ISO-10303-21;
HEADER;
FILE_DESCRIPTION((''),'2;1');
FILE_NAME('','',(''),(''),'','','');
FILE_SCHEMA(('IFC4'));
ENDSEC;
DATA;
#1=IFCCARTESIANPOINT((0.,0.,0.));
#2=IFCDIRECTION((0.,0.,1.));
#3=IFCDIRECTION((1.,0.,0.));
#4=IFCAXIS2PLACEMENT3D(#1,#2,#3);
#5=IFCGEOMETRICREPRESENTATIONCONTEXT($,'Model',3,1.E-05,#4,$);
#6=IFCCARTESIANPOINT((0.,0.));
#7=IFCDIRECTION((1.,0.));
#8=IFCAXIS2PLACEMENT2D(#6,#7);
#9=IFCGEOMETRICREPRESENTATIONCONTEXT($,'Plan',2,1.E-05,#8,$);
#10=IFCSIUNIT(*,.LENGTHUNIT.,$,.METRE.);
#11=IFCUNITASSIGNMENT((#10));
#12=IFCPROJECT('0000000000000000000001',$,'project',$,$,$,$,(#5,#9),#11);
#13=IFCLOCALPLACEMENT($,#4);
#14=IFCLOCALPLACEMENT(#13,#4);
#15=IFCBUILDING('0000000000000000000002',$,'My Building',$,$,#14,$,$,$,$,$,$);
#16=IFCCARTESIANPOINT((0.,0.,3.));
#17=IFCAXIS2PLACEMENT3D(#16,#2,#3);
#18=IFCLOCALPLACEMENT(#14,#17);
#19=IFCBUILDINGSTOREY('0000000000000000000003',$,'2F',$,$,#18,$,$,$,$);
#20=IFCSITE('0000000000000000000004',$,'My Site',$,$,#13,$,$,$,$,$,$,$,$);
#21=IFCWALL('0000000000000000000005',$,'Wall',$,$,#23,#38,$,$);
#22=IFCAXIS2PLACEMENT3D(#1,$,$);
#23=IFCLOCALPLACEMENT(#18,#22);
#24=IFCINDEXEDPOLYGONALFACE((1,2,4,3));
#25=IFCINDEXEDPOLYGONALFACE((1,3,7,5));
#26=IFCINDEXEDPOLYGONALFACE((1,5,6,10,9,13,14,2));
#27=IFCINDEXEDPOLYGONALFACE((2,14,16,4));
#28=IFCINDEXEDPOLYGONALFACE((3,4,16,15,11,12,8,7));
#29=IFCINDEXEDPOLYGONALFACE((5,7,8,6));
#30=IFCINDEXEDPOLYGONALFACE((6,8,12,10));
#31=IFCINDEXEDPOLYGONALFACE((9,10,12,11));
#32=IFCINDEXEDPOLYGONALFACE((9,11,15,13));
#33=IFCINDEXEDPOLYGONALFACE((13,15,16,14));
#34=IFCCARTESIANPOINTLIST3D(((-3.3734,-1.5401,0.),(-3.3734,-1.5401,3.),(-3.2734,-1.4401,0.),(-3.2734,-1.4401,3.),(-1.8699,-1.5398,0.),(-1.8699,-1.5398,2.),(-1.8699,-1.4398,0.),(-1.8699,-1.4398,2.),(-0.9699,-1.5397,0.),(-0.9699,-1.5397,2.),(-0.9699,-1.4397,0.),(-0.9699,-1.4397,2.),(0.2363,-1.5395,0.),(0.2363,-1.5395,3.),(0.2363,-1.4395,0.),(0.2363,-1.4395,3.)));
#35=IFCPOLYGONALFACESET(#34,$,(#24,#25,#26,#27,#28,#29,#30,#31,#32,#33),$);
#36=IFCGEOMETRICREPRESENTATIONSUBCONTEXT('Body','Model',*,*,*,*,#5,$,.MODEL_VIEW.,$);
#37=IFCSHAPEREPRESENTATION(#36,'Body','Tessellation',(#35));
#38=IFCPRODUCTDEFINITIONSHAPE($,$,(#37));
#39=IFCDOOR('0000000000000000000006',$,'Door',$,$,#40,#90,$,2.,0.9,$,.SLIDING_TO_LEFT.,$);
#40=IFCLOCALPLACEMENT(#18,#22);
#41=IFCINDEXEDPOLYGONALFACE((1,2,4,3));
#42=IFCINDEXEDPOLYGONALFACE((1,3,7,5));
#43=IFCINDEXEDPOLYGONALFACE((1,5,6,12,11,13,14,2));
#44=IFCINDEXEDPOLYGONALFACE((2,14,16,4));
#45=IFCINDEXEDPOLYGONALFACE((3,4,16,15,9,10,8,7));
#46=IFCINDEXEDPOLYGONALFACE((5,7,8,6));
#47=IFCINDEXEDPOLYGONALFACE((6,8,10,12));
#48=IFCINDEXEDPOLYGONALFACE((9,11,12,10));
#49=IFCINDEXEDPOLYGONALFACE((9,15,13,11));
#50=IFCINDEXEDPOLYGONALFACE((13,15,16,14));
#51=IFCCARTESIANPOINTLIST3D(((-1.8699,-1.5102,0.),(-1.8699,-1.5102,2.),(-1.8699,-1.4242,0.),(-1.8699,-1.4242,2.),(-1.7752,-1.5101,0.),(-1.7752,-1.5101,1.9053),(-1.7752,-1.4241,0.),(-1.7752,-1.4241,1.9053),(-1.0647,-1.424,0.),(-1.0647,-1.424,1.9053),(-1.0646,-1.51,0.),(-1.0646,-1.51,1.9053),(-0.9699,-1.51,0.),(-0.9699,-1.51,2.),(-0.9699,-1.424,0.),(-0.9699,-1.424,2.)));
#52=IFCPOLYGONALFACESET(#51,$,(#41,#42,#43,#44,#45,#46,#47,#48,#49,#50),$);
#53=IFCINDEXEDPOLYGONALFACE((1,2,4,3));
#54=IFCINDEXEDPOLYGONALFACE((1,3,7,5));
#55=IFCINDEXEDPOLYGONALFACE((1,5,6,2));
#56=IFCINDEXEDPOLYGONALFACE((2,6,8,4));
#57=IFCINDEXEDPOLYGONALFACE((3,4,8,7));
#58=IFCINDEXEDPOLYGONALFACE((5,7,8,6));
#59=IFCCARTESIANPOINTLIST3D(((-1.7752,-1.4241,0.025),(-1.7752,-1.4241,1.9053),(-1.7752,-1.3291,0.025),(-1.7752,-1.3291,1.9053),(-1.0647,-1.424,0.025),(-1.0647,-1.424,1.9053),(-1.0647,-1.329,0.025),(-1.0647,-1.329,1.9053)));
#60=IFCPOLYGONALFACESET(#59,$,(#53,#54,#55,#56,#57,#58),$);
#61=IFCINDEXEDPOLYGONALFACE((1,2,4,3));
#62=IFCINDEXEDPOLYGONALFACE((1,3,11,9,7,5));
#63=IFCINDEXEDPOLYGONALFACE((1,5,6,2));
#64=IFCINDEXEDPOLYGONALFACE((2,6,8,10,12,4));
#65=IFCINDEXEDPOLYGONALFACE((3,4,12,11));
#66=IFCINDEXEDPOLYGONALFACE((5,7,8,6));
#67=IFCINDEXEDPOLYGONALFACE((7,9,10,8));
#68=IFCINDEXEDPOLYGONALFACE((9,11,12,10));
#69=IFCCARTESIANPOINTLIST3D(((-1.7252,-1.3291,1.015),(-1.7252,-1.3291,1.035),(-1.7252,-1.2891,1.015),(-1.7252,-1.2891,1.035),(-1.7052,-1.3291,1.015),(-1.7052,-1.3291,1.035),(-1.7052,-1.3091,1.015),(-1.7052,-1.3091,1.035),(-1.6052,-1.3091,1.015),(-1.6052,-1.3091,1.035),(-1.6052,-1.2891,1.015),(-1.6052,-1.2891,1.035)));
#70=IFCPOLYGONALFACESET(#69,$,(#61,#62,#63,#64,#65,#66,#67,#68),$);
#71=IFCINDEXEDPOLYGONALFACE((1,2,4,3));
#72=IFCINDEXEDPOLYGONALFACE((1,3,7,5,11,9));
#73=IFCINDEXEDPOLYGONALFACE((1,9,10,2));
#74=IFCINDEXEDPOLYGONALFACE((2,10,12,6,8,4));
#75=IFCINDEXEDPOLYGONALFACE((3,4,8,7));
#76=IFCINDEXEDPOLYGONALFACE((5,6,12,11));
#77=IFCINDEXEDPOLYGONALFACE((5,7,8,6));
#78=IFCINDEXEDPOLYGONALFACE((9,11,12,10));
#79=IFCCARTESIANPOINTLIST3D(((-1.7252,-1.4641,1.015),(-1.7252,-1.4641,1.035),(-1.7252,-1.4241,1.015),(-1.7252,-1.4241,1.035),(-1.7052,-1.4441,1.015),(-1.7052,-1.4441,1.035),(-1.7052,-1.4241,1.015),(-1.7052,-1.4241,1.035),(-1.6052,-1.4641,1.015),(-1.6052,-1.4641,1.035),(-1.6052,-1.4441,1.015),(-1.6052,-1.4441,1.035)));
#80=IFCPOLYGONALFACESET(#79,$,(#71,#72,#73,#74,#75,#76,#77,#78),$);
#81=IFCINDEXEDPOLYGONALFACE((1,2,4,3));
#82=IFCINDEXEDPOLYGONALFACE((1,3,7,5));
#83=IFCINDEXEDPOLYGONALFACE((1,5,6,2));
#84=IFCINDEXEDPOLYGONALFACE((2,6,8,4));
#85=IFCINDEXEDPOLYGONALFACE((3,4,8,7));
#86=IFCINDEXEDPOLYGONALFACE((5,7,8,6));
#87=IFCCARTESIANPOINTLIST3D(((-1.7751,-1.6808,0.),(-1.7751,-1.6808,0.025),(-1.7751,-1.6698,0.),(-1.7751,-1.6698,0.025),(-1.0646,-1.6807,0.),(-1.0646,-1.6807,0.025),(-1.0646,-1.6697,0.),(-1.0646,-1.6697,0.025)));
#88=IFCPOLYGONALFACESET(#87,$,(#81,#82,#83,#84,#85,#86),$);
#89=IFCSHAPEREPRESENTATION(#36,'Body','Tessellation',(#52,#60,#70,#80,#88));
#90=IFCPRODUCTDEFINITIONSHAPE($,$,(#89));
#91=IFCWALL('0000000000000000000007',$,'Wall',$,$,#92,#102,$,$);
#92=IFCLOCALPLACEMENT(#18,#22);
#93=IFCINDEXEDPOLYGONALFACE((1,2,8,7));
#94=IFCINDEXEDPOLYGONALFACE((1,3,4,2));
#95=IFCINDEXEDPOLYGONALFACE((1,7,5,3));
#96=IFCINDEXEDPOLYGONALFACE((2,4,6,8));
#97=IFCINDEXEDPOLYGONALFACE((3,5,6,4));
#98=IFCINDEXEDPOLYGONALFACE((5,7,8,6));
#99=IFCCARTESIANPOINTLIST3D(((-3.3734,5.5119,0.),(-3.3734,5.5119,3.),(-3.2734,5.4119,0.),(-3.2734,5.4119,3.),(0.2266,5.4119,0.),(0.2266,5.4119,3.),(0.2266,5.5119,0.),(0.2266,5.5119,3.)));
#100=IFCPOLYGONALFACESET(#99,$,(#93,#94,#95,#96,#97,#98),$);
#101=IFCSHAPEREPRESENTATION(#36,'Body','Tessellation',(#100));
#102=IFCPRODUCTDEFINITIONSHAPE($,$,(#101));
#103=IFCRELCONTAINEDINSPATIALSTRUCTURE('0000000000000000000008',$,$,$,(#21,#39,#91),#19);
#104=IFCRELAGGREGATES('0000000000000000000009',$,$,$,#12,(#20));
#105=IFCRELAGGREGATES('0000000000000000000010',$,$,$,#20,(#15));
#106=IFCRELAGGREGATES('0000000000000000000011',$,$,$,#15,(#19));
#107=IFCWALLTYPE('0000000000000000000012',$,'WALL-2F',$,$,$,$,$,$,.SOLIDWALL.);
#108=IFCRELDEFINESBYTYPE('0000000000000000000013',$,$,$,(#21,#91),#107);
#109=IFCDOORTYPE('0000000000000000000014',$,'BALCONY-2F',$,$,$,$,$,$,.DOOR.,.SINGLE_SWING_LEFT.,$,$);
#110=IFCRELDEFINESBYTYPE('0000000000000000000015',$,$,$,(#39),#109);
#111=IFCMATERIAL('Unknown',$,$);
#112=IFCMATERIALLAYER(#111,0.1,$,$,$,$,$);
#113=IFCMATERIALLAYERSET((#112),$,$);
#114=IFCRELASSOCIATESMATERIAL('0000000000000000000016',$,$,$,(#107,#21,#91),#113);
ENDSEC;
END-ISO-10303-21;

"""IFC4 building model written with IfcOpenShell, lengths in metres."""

from ifc_helpers import new_model, entity, si_unit, frame, origin_with_axes, origin_2d_with_axis, place, context, subcontext, project, spatial, line, indexed_curve, outline, extrude, shape, source, transform, mapped, material, layer, layer_set, layer_usage, type_object, type_shapes, element, fill, save


model = new_model("IFC4")

# Units and contexts
model_context = context("Model", 3, precision=1e-05, world=origin_with_axes())
plan_context = context("Plan", 2, precision=1e-05, world=origin_2d_with_axis())
body_context_1 = subcontext(model_context, "Body", "Model", "MODEL_VIEW")
body_context_2 = subcontext(plan_context, "Body", "Plan", "PLAN_VIEW")
ifc_project = project(units=[si_unit("LENGTHUNIT", "METRE")], contexts=[model_context, plan_context])

# Site, building, storey
site_placement = place(None, origin_with_axes())
site = spatial("IfcSite", under=ifc_project, at=site_placement, Name="My Site")
building_placement = place(site_placement, origin_with_axes())
building = spatial("IfcBuilding", under=site, at=building_placement, Name="My Building")
storey_placement = place(building_placement, frame((0.0, 0.0, 3.0), z_axis=(0.0, 0.0, 1.0), x_axis=(1.0, 0.0, 0.0)))
storey = spatial("IfcBuildingStorey", under=building, at=storey_placement, Name="2F")

# Shared definitions
ifc_material = material(Name="Unknown")

# Shared definitions
ifc_layer_1 = layer(ifc_material, 0.1)
ifc_layer_set_1 = layer_set([ifc_layer_1])
wall_type = type_object("IfcWallType", Name="WALL-2F", PredefinedType="SOLIDWALL", material=ifc_layer_set_1)

# Wall, opening, door
ifc_layer_usage_1 = layer_usage(ifc_layer_set_1, "AXIS2", "POSITIVE", 0.0)
wall_1_placement = place(storey_placement, frame((-3.3734, -1.5401, 0.0), z_axis=(0.0, 0.0, 1.0), x_axis=(1.0, 0.000183, 0.0)))
wall_1 = element("IfcWall", 1, at=wall_1_placement, inside=storey, type_object=wall_type, material=ifc_layer_usage_1, Name="Wall", context=body_context_1, shape_type="SweptSolid", body=[
    extrude(outline(indexed_curve([(0.0, 0.0), (0.1, 0.1), (3.6097, 0.1), (3.6097, 0.0)], segments=[line(1, 2, 3, 4, 1)])), origin_with_axes(), (0.0, 0.0, 1.0), 3.0),
])
shared_shape_1 = source(origin_with_axes(), body_context_1, "Body", "SweptSolid", [
    extrude(outline(indexed_curve([(0.0, 0.0), (0.9, 0.0), (0.9, 2.0), (0.0, 2.0)], segments=[line(1, 2, 3, 4, 1)])), frame((0.0, -0.6, 0.0), z_axis=(0.0, -1.0, 0.0), x_axis=(1.0, 0.0, 0.0)), (0.0, 0.0, -1.0), 1.2),
])
opening_1_placement = place(wall_1_placement, frame((2.4035, 0.1, 0.0), z_axis=(0.0, 0.0, 1.0), x_axis=(-1.0, 0.0, 0.0)))
opening_1 = element("IfcOpeningElement", 2, at=opening_1_placement, cuts=wall_1, PredefinedType="OPENING", context=body_context_1, shape_type="MappedRepresentation", body=[
    mapped(shared_shape_1, transform((0.0, 0.0, 0.0), x_axis=(1.0, 0.0, 0.0), y_axis=(0.0, 1.0, 0.0), z_axis=(0.0, 0.0, 1.0), scale=1.0)),
])
door_type_1 = type_object("IfcDoorType", Name="BALCONY-2F", OperationType="SINGLE_SWING_LEFT", PredefinedType="DOOR")
shared_shape_2 = source(origin_with_axes(), body_context_1, "Body", "SweptSolid", [
    extrude(outline(indexed_curve([(0.0, 0.0), (0.0, 2.0), (0.9, 2.0), (0.9, 0.0), (0.8053, 0.0), (0.8053, 1.9053), (0.0947, 1.9053), (0.0947, 0.0)], segments=[line(1, 2, 3, 4, 5, 6, 7, 8, 1)])), frame((0.0, -0.0157, 0.0), z_axis=(0.0, -1.0, 0.0), x_axis=(1.0, 0.0, 0.0)), (0.0, 0.0, -1.0), 0.086),
    extrude(outline(indexed_curve([(0.0, 0.0), (0.7105, 0.0), (0.7105, 0.095), (0.0, 0.095)], segments=[line(1, 2, 3, 4, 1)])), frame((0.0947, -0.1107, 0.025), z_axis=(0.0, 0.0, 1.0), x_axis=(1.0, 0.0, 0.0)), (0.0, 0.0, 1.0), 1.8803),
    extrude(outline(indexed_curve([(0.0, 0.0), (0.0, -0.04), (-0.12, -0.04), (-0.12, -0.02), (-0.02, -0.02), (-0.02, 0.0)], segments=[line(1, 2, 3, 4, 5, 6, 1)])), frame((0.7553, -0.1107, 1.015), z_axis=(0.0, 0.0, 1.0), x_axis=(1.0, 0.0, 0.0)), (0.0, 0.0, 1.0), 0.02),
    extrude(outline(indexed_curve([(0.0, 0.0), (0.0, 0.04), (-0.12, 0.04), (-0.12, 0.02), (-0.02, 0.02), (-0.02, 0.0)], segments=[line(1, 2, 3, 4, 5, 6, 1)])), frame((0.7553, -0.0157, 1.015), z_axis=(0.0, 0.0, 1.0), x_axis=(1.0, 0.0, 0.0)), (0.0, 0.0, 1.0), 0.02),
    extrude(outline(indexed_curve([(0.0, 0.0), (0.7105, 0.0), (0.7105, 0.011), (0.0, 0.011)], segments=[line(1, 2, 3, 4, 1)])), frame((0.0947, 0.23, 0.0), z_axis=(0.0, 0.0, 1.0), x_axis=(1.0, 0.0, 0.0)), (0.0, 0.0, 1.0), 0.025),
])
shared_shape_3 = source(origin_with_axes(), body_context_2, "Body", "Curve2D", [
    entity("IfcIndexedPolyCurve", entity("IfcCartesianPointList2D", [[0.0, -0.0157], [0.0947, -0.0157], [0.0947, 0.0703], [0.0, 0.0703]]), [entity("IfcLineIndex", [1, 2, 3, 4, 1])]),
    entity("IfcIndexedPolyCurve", entity("IfcCartesianPointList2D", [[0.9, -0.0157], [0.8053, -0.0157], [0.8053, 0.0703], [0.9, 0.0703]]), [entity("IfcLineIndex", [1, 2, 3, 4, 1])]),
    entity("IfcIndexedPolyCurve", entity("IfcCartesianPointList2D", [[-0.2605, -0.1107], [0.45, -0.1107], [0.45, -0.0157], [-0.2605, -0.0157]]), [entity("IfcLineIndex", [1, 2, 3, 4, 1])]),
])
type_shapes(door_type_1, [shared_shape_2, shared_shape_3])
door_1_placement = place(opening_1_placement, frame((0.0, 0.0, 0.0), z_axis=(0.0, 0.0, 1.0), x_axis=(1.0, 0.0, 0.0)))
door_1 = element("IfcDoor", 3, at=door_1_placement, inside=storey, type_object=door_type_1, Name="Door", OperationType="SLIDING_TO_LEFT", OverallHeight=2.0, OverallWidth=0.9, shapes=[
    shape(body_context_1, "Body", "MappedRepresentation", [mapped(shared_shape_2, transform((0.0, 0.0, 0.0), x_axis=(1.0, 0.0, 0.0), y_axis=(0.0, 1.0, 0.0), z_axis=(0.0, 0.0, 1.0), scale=1.0))]),
    shape(body_context_2, "Body", "MappedRepresentation", [mapped(shared_shape_3, transform((0.0, 0.0, 0.0), x_axis=(1.0, 0.0, 0.0), y_axis=(0.0, 1.0, 0.0), z_axis=(0.0, 0.0, 1.0), scale=1.0))]),
])
fill(opening_1, door_1)

# Wall
ifc_layer_usage_2 = layer_usage(ifc_layer_set_1, "AXIS2", "POSITIVE", 0.0)
wall_2_placement = place(storey_placement, frame((0.2266, 5.5119, 0.0), z_axis=(0.0, 0.0, 1.0), x_axis=(-1.0, 0.0, 0.0)))
element("IfcWall", 4, at=wall_2_placement, inside=storey, type_object=wall_type, material=ifc_layer_usage_2, Name="Wall", context=body_context_1, shape_type="SweptSolid", body=[
    extrude(outline(indexed_curve([(0.0, 0.0), (0.0, 0.1), (3.5, 0.1), (3.6, 0.0)], segments=[line(1, 2, 3, 4, 1)])), origin_with_axes(), (0.0, 0.0, 1.0), 3.0),
])

save(model, "model.ifc")
